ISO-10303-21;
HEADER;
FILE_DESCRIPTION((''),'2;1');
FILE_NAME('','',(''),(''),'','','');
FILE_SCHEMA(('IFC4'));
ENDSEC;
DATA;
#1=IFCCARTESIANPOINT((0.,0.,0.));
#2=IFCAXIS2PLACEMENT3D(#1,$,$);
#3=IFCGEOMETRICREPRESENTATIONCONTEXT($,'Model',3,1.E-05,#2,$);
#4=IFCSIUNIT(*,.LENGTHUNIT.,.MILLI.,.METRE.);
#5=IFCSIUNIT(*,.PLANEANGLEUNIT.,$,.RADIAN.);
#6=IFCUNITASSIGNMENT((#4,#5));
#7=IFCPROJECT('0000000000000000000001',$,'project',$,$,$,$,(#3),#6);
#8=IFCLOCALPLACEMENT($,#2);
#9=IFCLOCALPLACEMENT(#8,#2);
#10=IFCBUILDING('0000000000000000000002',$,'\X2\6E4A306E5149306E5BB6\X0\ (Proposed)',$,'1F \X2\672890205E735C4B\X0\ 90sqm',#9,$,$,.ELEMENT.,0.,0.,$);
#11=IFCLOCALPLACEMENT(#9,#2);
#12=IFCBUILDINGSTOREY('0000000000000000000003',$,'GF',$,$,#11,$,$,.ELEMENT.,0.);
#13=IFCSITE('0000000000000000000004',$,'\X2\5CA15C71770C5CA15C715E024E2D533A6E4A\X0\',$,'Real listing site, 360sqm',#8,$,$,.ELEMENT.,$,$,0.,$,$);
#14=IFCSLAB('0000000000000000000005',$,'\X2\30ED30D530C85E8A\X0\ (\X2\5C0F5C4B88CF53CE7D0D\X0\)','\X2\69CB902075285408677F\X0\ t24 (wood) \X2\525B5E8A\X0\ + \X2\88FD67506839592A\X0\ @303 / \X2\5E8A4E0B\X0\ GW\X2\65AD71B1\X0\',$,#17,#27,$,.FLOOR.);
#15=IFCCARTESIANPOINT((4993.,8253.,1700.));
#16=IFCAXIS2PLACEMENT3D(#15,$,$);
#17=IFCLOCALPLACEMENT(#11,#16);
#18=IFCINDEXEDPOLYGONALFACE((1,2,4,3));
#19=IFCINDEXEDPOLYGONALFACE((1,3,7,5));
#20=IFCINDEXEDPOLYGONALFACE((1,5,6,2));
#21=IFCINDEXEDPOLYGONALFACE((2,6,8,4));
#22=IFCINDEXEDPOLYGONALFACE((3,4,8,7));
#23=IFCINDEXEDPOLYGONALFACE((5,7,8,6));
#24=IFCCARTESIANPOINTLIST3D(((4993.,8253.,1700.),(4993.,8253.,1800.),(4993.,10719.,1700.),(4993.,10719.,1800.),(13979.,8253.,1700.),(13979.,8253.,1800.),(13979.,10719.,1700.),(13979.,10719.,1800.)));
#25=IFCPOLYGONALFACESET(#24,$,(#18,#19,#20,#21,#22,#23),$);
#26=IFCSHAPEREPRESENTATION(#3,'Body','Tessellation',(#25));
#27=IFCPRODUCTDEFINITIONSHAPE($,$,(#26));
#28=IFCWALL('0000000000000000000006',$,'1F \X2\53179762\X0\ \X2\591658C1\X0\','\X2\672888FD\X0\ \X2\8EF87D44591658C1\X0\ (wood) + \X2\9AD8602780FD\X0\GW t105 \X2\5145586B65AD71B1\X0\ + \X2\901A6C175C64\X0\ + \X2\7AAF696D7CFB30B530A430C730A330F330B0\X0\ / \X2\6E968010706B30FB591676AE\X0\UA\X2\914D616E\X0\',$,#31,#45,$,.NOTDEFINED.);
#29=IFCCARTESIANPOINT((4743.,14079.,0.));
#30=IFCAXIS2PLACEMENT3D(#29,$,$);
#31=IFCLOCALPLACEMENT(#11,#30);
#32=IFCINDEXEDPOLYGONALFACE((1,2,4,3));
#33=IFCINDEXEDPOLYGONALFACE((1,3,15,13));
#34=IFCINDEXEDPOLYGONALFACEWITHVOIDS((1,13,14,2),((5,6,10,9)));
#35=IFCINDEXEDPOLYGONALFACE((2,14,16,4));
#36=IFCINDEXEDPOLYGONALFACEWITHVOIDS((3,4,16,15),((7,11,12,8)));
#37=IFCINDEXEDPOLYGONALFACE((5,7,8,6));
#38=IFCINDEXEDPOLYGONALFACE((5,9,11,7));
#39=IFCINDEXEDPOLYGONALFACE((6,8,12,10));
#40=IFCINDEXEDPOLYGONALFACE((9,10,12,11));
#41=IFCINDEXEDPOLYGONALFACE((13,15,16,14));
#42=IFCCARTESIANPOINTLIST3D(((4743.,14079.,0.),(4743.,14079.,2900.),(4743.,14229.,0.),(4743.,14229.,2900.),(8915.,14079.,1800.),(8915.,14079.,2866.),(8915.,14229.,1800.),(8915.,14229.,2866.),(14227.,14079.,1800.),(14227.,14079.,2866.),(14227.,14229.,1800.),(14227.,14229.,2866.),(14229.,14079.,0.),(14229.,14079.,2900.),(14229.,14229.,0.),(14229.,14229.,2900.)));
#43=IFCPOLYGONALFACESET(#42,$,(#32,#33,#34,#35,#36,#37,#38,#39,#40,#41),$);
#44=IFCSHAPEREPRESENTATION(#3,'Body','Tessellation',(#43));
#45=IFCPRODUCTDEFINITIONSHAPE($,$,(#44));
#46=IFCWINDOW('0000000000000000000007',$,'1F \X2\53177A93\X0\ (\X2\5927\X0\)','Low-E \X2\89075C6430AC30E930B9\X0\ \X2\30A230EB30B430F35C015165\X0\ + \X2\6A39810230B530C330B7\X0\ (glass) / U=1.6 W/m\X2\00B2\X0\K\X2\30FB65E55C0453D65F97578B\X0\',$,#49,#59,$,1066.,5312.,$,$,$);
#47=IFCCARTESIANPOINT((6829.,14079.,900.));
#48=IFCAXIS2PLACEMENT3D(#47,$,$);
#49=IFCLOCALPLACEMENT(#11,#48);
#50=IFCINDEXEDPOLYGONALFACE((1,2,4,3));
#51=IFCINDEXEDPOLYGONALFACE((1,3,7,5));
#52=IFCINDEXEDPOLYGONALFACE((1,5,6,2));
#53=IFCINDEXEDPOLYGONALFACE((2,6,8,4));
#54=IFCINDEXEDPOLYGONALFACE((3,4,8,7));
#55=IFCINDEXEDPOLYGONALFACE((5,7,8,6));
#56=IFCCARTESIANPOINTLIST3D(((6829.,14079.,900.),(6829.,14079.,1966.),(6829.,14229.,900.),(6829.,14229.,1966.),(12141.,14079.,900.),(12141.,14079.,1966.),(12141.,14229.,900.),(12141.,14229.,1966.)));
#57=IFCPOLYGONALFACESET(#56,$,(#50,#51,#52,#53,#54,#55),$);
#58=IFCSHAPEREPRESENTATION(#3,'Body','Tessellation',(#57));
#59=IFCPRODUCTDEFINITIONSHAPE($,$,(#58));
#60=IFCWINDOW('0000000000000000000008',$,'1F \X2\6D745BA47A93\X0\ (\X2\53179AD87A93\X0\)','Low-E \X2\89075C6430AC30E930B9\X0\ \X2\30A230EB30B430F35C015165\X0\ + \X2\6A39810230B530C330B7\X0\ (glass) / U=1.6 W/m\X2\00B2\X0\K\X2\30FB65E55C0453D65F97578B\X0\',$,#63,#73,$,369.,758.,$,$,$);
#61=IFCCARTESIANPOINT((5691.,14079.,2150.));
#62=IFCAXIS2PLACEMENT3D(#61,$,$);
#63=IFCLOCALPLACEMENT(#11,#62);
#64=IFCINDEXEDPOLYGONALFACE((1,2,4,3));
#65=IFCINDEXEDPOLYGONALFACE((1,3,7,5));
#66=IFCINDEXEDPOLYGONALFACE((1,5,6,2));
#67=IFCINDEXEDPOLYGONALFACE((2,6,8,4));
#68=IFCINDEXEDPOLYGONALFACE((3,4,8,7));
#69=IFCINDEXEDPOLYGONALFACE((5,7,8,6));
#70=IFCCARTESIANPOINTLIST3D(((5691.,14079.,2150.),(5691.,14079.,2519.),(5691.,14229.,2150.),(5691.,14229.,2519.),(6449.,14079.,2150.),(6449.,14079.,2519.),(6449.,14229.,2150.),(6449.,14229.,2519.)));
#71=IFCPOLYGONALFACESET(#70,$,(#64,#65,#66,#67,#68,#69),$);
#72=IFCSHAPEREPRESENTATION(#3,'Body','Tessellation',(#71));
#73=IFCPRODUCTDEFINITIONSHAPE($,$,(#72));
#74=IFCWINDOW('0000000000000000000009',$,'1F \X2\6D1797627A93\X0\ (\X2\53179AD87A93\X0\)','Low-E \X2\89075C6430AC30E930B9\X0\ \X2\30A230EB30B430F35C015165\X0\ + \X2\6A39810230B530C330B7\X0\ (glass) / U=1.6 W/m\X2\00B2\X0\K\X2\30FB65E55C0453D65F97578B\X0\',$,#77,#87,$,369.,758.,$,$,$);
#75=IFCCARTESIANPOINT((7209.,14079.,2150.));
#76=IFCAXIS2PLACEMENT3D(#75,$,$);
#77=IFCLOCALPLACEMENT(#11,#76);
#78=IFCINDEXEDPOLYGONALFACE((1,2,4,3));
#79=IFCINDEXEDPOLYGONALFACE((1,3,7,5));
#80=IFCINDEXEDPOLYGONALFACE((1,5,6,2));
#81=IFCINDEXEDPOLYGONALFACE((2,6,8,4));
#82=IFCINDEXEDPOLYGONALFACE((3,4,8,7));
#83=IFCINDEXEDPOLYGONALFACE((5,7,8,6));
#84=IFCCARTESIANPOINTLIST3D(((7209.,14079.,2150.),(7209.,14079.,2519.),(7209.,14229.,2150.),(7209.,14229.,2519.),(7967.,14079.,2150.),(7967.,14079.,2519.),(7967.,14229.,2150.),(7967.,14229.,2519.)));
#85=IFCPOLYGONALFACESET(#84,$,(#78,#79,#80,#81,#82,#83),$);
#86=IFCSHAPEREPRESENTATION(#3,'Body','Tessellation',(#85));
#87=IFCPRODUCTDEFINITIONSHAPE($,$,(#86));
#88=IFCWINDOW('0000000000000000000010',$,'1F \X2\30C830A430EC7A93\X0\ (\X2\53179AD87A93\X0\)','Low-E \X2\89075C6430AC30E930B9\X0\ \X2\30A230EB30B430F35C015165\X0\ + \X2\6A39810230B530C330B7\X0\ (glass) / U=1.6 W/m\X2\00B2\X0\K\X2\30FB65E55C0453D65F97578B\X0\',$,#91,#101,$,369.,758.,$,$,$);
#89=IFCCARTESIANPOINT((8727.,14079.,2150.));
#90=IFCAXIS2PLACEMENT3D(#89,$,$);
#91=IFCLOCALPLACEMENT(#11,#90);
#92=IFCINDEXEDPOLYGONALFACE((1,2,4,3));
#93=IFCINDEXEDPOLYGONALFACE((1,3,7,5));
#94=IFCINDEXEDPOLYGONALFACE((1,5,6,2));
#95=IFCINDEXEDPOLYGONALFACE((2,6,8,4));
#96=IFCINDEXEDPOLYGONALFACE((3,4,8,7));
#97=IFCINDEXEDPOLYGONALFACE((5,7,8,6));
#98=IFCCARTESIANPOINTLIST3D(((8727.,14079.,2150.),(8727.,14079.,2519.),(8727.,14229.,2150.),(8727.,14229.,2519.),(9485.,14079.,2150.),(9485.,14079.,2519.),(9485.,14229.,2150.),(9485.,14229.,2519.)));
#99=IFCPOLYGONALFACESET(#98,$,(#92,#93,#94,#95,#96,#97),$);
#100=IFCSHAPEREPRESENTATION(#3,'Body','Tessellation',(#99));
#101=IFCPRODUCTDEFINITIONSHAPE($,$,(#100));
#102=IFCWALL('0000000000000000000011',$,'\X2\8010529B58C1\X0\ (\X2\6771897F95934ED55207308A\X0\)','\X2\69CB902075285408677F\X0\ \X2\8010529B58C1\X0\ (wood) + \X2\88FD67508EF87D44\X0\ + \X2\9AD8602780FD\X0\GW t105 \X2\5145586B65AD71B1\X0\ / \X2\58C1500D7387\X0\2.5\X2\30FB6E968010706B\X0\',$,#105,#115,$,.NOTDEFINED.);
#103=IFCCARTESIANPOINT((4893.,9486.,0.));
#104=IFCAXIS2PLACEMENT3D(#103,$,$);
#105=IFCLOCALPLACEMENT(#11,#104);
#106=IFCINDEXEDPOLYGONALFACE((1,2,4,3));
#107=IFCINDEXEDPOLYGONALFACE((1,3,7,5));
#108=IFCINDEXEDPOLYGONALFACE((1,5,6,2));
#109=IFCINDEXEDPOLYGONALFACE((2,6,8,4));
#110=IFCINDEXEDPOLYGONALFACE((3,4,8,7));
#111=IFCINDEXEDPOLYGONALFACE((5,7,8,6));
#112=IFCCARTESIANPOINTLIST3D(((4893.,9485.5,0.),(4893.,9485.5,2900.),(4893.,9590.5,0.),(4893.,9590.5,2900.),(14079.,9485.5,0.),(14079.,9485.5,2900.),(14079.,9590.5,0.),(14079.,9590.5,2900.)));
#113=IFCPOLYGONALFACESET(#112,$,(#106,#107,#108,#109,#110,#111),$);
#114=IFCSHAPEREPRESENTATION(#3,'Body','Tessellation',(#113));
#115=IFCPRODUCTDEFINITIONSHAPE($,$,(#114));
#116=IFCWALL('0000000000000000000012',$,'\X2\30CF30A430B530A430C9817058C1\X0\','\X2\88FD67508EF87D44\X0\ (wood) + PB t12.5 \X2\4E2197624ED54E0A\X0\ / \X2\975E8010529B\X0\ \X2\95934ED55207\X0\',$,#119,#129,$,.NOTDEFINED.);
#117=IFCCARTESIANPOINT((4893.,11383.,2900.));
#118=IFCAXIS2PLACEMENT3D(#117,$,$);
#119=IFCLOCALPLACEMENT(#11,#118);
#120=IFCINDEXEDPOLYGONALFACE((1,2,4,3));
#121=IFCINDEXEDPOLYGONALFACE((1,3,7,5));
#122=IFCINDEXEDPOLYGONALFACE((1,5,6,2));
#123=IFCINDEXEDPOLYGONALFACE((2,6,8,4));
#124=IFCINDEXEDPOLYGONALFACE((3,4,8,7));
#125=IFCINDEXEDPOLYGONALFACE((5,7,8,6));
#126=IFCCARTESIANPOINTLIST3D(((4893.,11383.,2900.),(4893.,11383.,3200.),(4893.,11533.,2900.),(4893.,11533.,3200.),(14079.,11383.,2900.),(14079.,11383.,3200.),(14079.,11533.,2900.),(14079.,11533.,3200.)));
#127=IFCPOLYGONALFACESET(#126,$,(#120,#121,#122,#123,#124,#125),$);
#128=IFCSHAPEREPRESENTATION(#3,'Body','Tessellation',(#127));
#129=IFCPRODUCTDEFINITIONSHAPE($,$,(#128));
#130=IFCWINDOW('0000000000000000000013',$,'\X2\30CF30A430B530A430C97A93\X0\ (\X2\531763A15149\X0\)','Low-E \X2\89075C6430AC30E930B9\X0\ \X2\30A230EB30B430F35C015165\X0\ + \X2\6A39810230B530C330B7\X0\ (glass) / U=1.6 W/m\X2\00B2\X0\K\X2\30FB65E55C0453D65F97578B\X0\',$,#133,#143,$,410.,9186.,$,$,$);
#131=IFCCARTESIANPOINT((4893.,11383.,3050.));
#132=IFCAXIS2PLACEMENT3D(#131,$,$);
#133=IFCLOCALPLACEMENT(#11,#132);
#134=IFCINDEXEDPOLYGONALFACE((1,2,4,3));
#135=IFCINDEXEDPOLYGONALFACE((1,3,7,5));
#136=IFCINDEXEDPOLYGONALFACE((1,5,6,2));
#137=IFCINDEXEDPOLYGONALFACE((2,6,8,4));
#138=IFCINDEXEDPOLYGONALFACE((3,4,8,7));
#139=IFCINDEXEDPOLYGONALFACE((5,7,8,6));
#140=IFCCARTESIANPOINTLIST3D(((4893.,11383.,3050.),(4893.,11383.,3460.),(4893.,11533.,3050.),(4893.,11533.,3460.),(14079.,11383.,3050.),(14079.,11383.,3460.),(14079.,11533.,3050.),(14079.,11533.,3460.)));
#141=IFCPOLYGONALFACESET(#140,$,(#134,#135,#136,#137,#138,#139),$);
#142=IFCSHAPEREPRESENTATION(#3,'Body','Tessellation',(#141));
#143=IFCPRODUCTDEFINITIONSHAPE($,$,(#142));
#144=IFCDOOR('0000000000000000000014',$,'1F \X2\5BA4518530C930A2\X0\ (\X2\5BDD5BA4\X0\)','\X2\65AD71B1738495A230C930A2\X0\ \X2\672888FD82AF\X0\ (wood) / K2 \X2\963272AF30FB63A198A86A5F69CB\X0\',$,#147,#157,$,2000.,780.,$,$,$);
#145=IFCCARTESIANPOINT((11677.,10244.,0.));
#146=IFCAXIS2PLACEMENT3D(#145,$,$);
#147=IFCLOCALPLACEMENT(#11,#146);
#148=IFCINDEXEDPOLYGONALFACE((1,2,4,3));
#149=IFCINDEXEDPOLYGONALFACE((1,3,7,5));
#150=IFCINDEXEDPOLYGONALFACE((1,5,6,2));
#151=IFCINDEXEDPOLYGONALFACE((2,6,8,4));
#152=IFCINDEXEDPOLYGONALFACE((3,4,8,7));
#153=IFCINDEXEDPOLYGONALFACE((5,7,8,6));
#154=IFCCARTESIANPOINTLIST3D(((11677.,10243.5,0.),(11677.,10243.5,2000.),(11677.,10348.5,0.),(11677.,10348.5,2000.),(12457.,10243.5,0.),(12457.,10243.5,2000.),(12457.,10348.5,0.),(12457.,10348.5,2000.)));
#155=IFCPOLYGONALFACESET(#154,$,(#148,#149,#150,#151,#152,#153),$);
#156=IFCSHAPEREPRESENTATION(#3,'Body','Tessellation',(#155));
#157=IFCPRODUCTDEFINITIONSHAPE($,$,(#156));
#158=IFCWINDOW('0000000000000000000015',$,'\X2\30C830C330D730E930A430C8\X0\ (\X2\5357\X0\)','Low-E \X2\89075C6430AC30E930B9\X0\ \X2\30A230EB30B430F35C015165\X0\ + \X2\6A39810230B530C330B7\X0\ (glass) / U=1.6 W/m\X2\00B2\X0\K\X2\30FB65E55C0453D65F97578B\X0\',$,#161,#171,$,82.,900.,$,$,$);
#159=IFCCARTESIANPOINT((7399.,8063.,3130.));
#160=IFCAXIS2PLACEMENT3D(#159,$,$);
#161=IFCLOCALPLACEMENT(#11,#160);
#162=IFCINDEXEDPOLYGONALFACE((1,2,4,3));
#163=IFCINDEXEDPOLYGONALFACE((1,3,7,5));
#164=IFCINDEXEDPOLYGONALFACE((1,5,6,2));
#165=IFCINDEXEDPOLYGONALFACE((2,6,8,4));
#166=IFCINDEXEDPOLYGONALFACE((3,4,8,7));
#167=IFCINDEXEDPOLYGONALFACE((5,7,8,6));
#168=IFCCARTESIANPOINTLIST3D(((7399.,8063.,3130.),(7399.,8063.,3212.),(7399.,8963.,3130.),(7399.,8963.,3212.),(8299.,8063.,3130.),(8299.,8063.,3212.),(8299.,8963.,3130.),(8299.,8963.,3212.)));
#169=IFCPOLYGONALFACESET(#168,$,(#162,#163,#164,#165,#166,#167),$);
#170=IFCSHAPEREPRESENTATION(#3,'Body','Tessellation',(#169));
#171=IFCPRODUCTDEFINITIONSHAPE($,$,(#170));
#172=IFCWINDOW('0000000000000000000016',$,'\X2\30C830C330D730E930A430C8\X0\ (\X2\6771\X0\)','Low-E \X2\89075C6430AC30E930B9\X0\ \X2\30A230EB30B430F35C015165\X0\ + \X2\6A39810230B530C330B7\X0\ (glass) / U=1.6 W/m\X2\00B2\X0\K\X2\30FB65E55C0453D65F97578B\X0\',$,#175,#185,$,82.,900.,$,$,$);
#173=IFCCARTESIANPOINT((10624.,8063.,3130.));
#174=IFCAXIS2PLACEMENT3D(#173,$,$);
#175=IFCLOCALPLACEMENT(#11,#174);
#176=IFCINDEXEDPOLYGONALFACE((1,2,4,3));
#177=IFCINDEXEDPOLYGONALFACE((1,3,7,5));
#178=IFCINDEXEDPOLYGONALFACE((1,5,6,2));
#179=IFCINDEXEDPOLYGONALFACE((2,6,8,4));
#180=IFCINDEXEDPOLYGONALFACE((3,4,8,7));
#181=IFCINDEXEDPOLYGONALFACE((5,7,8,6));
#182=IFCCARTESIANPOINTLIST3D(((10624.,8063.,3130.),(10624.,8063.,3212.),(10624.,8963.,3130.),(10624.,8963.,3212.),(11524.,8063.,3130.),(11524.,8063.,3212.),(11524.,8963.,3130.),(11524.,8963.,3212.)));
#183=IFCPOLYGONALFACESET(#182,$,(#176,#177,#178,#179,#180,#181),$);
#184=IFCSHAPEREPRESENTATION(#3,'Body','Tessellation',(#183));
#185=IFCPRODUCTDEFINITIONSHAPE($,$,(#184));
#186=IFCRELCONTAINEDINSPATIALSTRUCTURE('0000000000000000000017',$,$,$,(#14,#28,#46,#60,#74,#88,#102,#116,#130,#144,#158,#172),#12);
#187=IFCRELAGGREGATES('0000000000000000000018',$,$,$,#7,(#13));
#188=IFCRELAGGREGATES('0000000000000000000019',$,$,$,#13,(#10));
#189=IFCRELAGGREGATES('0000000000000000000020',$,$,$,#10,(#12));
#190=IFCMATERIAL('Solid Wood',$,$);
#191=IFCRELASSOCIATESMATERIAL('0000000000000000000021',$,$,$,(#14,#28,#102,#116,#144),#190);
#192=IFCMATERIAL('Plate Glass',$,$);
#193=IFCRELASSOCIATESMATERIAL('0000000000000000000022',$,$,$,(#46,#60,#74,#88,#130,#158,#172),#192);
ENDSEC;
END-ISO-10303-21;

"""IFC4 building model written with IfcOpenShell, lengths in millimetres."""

from ifc_helpers import new_model, si_unit, frame, frame_2d, origin, place, context, project, spatial, rectangle, extrude, material, element, fill, save


model = new_model("IFC4")

# Units and contexts
model_context = context("Model", 3, precision=1e-05, world=origin())
ifc_project = project(units=[si_unit("LENGTHUNIT", "METRE", prefix="MILLI"), si_unit("PLANEANGLEUNIT", "RADIAN")], contexts=[model_context])

# Site, building, storey
site_placement = place(None, origin())
site = spatial("IfcSite", under=ifc_project, at=site_placement, Name="岡山県岡山市中区湊", ObjectType="Real listing site, 360sqm", CompositionType="ELEMENT", RefElevation=0.0)
building_placement = place(site_placement, origin())
building = spatial("IfcBuilding", under=site, at=building_placement, Name="湊の光の家 (Proposed)", ObjectType="1F 木造平屋 90sqm", CompositionType="ELEMENT", ElevationOfRefHeight=0.0, ElevationOfTerrain=0.0)
storey_placement = place(building_placement, origin())
storey = spatial("IfcBuildingStorey", under=building, at=storey_placement, Name="GF", CompositionType="ELEMENT", Elevation=0.0)

# Slab
ifc_material_1 = material(Name="Solid Wood")
slab_placement = place(storey_placement, frame((4993.0, 8253.0, 1700.0)))
element("IfcSlab", 1, at=slab_placement, inside=storey, material=ifc_material_1, Name="ロフト床 (小屋裏収納)", Description="構造用合板 t24 (wood) 剛床 + 製材根太 @303 / 床下 GW断熱", PredefinedType="FLOOR", context=model_context, shape_type="SweptSolid", body=[
    extrude(rectangle(XDim=8986.0, YDim=2466.0, at=frame_2d((4493.0, 1233.0))), frame((4993.0, 8253.0, 1700.0)), (0.0, 0.0, 1.0), 100.0),
])

# Wall, openings, windows
wall_1_placement = place(storey_placement, frame((4743.0, 14079.0, 0.0)))
wall_1 = element("IfcWall", 2, at=wall_1_placement, inside=storey, material=ifc_material_1, Name="1F 北面 外壁", Description="木製 軸組外壁 (wood) + 高性能GW t105 充填断熱 + 通気層 + 窯業系サイディング / 準耐火・外皮UA配慮", PredefinedType="NOTDEFINED", context=model_context, shape_type="SweptSolid", body=[
    extrude(rectangle(XDim=9486.0, YDim=150.0, at=frame_2d((4743.0, 75.0))), frame((4743.0, 14079.0, 0.0)), (0.0, 0.0, 1.0), 2900.0),
])
opening_1_placement = place(storey_placement, frame((6829.0, 14079.0, 900.0)))
opening_1 = element("IfcOpeningElement", 3, at=opening_1_placement, cuts=wall_1, PredefinedType="NOTDEFINED", context=model_context, shape_type="SweptSolid", body=[
    extrude(rectangle(XDim=5312.0, YDim=150.0, at=frame_2d((2656.0, 75.0))), frame((6829.0, 14079.0, 900.0)), (0.0, 0.0, 1.0), 1066.0),
])
opening_2_placement = place(storey_placement, frame((5691.0, 14079.0, 2150.0)))
opening_2 = element("IfcOpeningElement", 4, at=opening_2_placement, cuts=wall_1, PredefinedType="NOTDEFINED", context=model_context, shape_type="SweptSolid", body=[
    extrude(rectangle(XDim=758.0, YDim=150.0, at=frame_2d((379.0, 75.0))), frame((5691.0, 14079.0, 2150.0)), (0.0, 0.0, 1.0), 369.0),
])
opening_3_placement = place(storey_placement, frame((7209.0, 14079.0, 2150.0)))
opening_3 = element("IfcOpeningElement", 5, at=opening_3_placement, cuts=wall_1, PredefinedType="NOTDEFINED", context=model_context, shape_type="SweptSolid", body=[
    extrude(rectangle(XDim=758.0, YDim=150.0, at=frame_2d((379.0, 75.0))), frame((7209.0, 14079.0, 2150.0)), (0.0, 0.0, 1.0), 369.0),
])
opening_4_placement = place(storey_placement, frame((8727.0, 14079.0, 2150.0)))
opening_4 = element("IfcOpeningElement", 6, at=opening_4_placement, cuts=wall_1, PredefinedType="NOTDEFINED", context=model_context, shape_type="SweptSolid", body=[
    extrude(rectangle(XDim=758.0, YDim=150.0, at=frame_2d((379.0, 75.0))), frame((8727.0, 14079.0, 2150.0)), (0.0, 0.0, 1.0), 369.0),
])
ifc_material_2 = material(Name="Plate Glass")
window_1_placement = place(storey_placement, frame((6829.0, 14079.0, 900.0)))
window_1 = element("IfcWindow", 7, at=window_1_placement, inside=storey, material=ifc_material_2, Name="1F 北窓 (大)", Description="Low-E 複層ガラス アルゴン封入 + 樹脂サッシ (glass) / U=1.6 W/m²K・日射取得型", OverallHeight=1066.0, OverallWidth=5312.0, context=model_context, shape_type="SweptSolid", body=[
    extrude(rectangle(XDim=5312.0, YDim=150.0, at=frame_2d((2656.0, 75.0))), frame((6829.0, 14079.0, 900.0)), (0.0, 0.0, 1.0), 1066.0),
])
fill(opening_1, window_1)
window_2_placement = place(storey_placement, frame((5691.0, 14079.0, 2150.0)))
window_2 = element("IfcWindow", 8, at=window_2_placement, inside=storey, material=ifc_material_2, Name="1F 浴室窓 (北高窓)", Description="Low-E 複層ガラス アルゴン封入 + 樹脂サッシ (glass) / U=1.6 W/m²K・日射取得型", OverallHeight=369.0, OverallWidth=758.0, context=model_context, shape_type="SweptSolid", body=[
    extrude(rectangle(XDim=758.0, YDim=150.0, at=frame_2d((379.0, 75.0))), frame((5691.0, 14079.0, 2150.0)), (0.0, 0.0, 1.0), 369.0),
])
fill(opening_2, window_2)
window_3_placement = place(storey_placement, frame((7209.0, 14079.0, 2150.0)))
window_3 = element("IfcWindow", 9, at=window_3_placement, inside=storey, material=ifc_material_2, Name="1F 洗面窓 (北高窓)", Description="Low-E 複層ガラス アルゴン封入 + 樹脂サッシ (glass) / U=1.6 W/m²K・日射取得型", OverallHeight=369.0, OverallWidth=758.0, context=model_context, shape_type="SweptSolid", body=[
    extrude(rectangle(XDim=758.0, YDim=150.0, at=frame_2d((379.0, 75.0))), frame((7209.0, 14079.0, 2150.0)), (0.0, 0.0, 1.0), 369.0),
])
fill(opening_3, window_3)
window_4_placement = place(storey_placement, frame((8727.0, 14079.0, 2150.0)))
window_4 = element("IfcWindow", 10, at=window_4_placement, inside=storey, material=ifc_material_2, Name="1F トイレ窓 (北高窓)", Description="Low-E 複層ガラス アルゴン封入 + 樹脂サッシ (glass) / U=1.6 W/m²K・日射取得型", OverallHeight=369.0, OverallWidth=758.0, context=model_context, shape_type="SweptSolid", body=[
    extrude(rectangle(XDim=758.0, YDim=150.0, at=frame_2d((379.0, 75.0))), frame((8727.0, 14079.0, 2150.0)), (0.0, 0.0, 1.0), 369.0),
])
fill(opening_4, window_4)

# Wall
wall_2_placement = place(storey_placement, frame((4893.0, 9486.0, 0.0)))
element("IfcWall", 11, at=wall_2_placement, inside=storey, material=ifc_material_1, Name="耐力壁 (東西間仕切り)", Description="構造用合板 耐力壁 (wood) + 製材軸組 + 高性能GW t105 充填断熱 / 壁倍率2.5・準耐火", PredefinedType="NOTDEFINED", context=model_context, shape_type="SweptSolid", body=[
    extrude(rectangle(XDim=9186.0, YDim=105.0, at=frame_2d((4593.0, 52.0))), frame((4893.0, 9486.0, 0.0)), (0.0, 0.0, 1.0), 2900.0),
])

# Wall, opening, window
wall_3_placement = place(storey_placement, frame((4893.0, 11383.0, 2900.0)))
wall_3 = element("IfcWall", 12, at=wall_3_placement, inside=storey, material=ifc_material_1, Name="ハイサイド腰壁", Description="製材軸組 (wood) + PB t12.5 両面仕上 / 非耐力 間仕切", PredefinedType="NOTDEFINED", context=model_context, shape_type="SweptSolid", body=[
    extrude(rectangle(XDim=9186.0, YDim=150.0, at=frame_2d((4593.0, 75.0))), frame((4893.0, 11383.0, 2900.0)), (0.0, 0.0, 1.0), 700.0),
])
opening_5_placement = place(storey_placement, frame((4893.0, 11383.0, 3050.0)))
opening_5 = element("IfcOpeningElement", 13, at=opening_5_placement, cuts=wall_3, PredefinedType="NOTDEFINED", context=model_context, shape_type="SweptSolid", body=[
    extrude(rectangle(XDim=9186.0, YDim=150.0, at=frame_2d((4593.0, 75.0))), frame((4893.0, 11383.0, 3050.0)), (0.0, 0.0, 1.0), 410.0),
])
window_5_placement = place(storey_placement, frame((4893.0, 11383.0, 3050.0)))
window_5 = element("IfcWindow", 14, at=window_5_placement, inside=storey, material=ifc_material_2, Name="ハイサイド窓 (北採光)", Description="Low-E 複層ガラス アルゴン封入 + 樹脂サッシ (glass) / U=1.6 W/m²K・日射取得型", OverallHeight=410.0, OverallWidth=9186.0, context=model_context, shape_type="SweptSolid", body=[
    extrude(rectangle(XDim=9186.0, YDim=150.0, at=frame_2d((4593.0, 75.0))), frame((4893.0, 11383.0, 3050.0)), (0.0, 0.0, 1.0), 410.0),
])
fill(opening_5, window_5)

# Door
door_1_placement = place(storey_placement, frame((11677.0, 10244.0, 0.0)))
element("IfcDoor", 15, at=door_1_placement, inside=storey, material=ifc_material_1, Name="1F 室内ドア (寝室)", Description="断熱玄関ドア 木製芯 (wood) / K2 防犯・採風機構", OverallHeight=2000.0, OverallWidth=780.0, context=model_context, shape_type="SweptSolid", body=[
    extrude(rectangle(XDim=780.0, YDim=105.0, at=frame_2d((390.0, 52.0))), frame((11677.0, 10244.0, 0.0)), (0.0, 0.0, 1.0), 2000.0),
])

# Windows
window_6_placement = place(storey_placement, frame((7399.0, 8063.0, 3130.0)))
element("IfcWindow", 16, at=window_6_placement, inside=storey, material=ifc_material_2, Name="トップライト (南)", Description="Low-E 複層ガラス アルゴン封入 + 樹脂サッシ (glass) / U=1.6 W/m²K・日射取得型", OverallHeight=82.0, OverallWidth=900.0, context=model_context, shape_type="SweptSolid", body=[
    extrude(rectangle(XDim=900.0, YDim=900.0, at=frame_2d((450.0, 450.0))), frame((7399.0, 8063.0, 3130.0)), (0.0, 0.0, 1.0), 82.0),
])
window_7_placement = place(storey_placement, frame((10624.0, 8063.0, 3130.0)))
element("IfcWindow", 17, at=window_7_placement, inside=storey, material=ifc_material_2, Name="トップライト (東)", Description="Low-E 複層ガラス アルゴン封入 + 樹脂サッシ (glass) / U=1.6 W/m²K・日射取得型", OverallHeight=82.0, OverallWidth=900.0, context=model_context, shape_type="SweptSolid", body=[
    extrude(rectangle(XDim=900.0, YDim=900.0, at=frame_2d((450.0, 450.0))), frame((10624.0, 8063.0, 3130.0)), (0.0, 0.0, 1.0), 82.0),
])

save(model, "model.ifc")
